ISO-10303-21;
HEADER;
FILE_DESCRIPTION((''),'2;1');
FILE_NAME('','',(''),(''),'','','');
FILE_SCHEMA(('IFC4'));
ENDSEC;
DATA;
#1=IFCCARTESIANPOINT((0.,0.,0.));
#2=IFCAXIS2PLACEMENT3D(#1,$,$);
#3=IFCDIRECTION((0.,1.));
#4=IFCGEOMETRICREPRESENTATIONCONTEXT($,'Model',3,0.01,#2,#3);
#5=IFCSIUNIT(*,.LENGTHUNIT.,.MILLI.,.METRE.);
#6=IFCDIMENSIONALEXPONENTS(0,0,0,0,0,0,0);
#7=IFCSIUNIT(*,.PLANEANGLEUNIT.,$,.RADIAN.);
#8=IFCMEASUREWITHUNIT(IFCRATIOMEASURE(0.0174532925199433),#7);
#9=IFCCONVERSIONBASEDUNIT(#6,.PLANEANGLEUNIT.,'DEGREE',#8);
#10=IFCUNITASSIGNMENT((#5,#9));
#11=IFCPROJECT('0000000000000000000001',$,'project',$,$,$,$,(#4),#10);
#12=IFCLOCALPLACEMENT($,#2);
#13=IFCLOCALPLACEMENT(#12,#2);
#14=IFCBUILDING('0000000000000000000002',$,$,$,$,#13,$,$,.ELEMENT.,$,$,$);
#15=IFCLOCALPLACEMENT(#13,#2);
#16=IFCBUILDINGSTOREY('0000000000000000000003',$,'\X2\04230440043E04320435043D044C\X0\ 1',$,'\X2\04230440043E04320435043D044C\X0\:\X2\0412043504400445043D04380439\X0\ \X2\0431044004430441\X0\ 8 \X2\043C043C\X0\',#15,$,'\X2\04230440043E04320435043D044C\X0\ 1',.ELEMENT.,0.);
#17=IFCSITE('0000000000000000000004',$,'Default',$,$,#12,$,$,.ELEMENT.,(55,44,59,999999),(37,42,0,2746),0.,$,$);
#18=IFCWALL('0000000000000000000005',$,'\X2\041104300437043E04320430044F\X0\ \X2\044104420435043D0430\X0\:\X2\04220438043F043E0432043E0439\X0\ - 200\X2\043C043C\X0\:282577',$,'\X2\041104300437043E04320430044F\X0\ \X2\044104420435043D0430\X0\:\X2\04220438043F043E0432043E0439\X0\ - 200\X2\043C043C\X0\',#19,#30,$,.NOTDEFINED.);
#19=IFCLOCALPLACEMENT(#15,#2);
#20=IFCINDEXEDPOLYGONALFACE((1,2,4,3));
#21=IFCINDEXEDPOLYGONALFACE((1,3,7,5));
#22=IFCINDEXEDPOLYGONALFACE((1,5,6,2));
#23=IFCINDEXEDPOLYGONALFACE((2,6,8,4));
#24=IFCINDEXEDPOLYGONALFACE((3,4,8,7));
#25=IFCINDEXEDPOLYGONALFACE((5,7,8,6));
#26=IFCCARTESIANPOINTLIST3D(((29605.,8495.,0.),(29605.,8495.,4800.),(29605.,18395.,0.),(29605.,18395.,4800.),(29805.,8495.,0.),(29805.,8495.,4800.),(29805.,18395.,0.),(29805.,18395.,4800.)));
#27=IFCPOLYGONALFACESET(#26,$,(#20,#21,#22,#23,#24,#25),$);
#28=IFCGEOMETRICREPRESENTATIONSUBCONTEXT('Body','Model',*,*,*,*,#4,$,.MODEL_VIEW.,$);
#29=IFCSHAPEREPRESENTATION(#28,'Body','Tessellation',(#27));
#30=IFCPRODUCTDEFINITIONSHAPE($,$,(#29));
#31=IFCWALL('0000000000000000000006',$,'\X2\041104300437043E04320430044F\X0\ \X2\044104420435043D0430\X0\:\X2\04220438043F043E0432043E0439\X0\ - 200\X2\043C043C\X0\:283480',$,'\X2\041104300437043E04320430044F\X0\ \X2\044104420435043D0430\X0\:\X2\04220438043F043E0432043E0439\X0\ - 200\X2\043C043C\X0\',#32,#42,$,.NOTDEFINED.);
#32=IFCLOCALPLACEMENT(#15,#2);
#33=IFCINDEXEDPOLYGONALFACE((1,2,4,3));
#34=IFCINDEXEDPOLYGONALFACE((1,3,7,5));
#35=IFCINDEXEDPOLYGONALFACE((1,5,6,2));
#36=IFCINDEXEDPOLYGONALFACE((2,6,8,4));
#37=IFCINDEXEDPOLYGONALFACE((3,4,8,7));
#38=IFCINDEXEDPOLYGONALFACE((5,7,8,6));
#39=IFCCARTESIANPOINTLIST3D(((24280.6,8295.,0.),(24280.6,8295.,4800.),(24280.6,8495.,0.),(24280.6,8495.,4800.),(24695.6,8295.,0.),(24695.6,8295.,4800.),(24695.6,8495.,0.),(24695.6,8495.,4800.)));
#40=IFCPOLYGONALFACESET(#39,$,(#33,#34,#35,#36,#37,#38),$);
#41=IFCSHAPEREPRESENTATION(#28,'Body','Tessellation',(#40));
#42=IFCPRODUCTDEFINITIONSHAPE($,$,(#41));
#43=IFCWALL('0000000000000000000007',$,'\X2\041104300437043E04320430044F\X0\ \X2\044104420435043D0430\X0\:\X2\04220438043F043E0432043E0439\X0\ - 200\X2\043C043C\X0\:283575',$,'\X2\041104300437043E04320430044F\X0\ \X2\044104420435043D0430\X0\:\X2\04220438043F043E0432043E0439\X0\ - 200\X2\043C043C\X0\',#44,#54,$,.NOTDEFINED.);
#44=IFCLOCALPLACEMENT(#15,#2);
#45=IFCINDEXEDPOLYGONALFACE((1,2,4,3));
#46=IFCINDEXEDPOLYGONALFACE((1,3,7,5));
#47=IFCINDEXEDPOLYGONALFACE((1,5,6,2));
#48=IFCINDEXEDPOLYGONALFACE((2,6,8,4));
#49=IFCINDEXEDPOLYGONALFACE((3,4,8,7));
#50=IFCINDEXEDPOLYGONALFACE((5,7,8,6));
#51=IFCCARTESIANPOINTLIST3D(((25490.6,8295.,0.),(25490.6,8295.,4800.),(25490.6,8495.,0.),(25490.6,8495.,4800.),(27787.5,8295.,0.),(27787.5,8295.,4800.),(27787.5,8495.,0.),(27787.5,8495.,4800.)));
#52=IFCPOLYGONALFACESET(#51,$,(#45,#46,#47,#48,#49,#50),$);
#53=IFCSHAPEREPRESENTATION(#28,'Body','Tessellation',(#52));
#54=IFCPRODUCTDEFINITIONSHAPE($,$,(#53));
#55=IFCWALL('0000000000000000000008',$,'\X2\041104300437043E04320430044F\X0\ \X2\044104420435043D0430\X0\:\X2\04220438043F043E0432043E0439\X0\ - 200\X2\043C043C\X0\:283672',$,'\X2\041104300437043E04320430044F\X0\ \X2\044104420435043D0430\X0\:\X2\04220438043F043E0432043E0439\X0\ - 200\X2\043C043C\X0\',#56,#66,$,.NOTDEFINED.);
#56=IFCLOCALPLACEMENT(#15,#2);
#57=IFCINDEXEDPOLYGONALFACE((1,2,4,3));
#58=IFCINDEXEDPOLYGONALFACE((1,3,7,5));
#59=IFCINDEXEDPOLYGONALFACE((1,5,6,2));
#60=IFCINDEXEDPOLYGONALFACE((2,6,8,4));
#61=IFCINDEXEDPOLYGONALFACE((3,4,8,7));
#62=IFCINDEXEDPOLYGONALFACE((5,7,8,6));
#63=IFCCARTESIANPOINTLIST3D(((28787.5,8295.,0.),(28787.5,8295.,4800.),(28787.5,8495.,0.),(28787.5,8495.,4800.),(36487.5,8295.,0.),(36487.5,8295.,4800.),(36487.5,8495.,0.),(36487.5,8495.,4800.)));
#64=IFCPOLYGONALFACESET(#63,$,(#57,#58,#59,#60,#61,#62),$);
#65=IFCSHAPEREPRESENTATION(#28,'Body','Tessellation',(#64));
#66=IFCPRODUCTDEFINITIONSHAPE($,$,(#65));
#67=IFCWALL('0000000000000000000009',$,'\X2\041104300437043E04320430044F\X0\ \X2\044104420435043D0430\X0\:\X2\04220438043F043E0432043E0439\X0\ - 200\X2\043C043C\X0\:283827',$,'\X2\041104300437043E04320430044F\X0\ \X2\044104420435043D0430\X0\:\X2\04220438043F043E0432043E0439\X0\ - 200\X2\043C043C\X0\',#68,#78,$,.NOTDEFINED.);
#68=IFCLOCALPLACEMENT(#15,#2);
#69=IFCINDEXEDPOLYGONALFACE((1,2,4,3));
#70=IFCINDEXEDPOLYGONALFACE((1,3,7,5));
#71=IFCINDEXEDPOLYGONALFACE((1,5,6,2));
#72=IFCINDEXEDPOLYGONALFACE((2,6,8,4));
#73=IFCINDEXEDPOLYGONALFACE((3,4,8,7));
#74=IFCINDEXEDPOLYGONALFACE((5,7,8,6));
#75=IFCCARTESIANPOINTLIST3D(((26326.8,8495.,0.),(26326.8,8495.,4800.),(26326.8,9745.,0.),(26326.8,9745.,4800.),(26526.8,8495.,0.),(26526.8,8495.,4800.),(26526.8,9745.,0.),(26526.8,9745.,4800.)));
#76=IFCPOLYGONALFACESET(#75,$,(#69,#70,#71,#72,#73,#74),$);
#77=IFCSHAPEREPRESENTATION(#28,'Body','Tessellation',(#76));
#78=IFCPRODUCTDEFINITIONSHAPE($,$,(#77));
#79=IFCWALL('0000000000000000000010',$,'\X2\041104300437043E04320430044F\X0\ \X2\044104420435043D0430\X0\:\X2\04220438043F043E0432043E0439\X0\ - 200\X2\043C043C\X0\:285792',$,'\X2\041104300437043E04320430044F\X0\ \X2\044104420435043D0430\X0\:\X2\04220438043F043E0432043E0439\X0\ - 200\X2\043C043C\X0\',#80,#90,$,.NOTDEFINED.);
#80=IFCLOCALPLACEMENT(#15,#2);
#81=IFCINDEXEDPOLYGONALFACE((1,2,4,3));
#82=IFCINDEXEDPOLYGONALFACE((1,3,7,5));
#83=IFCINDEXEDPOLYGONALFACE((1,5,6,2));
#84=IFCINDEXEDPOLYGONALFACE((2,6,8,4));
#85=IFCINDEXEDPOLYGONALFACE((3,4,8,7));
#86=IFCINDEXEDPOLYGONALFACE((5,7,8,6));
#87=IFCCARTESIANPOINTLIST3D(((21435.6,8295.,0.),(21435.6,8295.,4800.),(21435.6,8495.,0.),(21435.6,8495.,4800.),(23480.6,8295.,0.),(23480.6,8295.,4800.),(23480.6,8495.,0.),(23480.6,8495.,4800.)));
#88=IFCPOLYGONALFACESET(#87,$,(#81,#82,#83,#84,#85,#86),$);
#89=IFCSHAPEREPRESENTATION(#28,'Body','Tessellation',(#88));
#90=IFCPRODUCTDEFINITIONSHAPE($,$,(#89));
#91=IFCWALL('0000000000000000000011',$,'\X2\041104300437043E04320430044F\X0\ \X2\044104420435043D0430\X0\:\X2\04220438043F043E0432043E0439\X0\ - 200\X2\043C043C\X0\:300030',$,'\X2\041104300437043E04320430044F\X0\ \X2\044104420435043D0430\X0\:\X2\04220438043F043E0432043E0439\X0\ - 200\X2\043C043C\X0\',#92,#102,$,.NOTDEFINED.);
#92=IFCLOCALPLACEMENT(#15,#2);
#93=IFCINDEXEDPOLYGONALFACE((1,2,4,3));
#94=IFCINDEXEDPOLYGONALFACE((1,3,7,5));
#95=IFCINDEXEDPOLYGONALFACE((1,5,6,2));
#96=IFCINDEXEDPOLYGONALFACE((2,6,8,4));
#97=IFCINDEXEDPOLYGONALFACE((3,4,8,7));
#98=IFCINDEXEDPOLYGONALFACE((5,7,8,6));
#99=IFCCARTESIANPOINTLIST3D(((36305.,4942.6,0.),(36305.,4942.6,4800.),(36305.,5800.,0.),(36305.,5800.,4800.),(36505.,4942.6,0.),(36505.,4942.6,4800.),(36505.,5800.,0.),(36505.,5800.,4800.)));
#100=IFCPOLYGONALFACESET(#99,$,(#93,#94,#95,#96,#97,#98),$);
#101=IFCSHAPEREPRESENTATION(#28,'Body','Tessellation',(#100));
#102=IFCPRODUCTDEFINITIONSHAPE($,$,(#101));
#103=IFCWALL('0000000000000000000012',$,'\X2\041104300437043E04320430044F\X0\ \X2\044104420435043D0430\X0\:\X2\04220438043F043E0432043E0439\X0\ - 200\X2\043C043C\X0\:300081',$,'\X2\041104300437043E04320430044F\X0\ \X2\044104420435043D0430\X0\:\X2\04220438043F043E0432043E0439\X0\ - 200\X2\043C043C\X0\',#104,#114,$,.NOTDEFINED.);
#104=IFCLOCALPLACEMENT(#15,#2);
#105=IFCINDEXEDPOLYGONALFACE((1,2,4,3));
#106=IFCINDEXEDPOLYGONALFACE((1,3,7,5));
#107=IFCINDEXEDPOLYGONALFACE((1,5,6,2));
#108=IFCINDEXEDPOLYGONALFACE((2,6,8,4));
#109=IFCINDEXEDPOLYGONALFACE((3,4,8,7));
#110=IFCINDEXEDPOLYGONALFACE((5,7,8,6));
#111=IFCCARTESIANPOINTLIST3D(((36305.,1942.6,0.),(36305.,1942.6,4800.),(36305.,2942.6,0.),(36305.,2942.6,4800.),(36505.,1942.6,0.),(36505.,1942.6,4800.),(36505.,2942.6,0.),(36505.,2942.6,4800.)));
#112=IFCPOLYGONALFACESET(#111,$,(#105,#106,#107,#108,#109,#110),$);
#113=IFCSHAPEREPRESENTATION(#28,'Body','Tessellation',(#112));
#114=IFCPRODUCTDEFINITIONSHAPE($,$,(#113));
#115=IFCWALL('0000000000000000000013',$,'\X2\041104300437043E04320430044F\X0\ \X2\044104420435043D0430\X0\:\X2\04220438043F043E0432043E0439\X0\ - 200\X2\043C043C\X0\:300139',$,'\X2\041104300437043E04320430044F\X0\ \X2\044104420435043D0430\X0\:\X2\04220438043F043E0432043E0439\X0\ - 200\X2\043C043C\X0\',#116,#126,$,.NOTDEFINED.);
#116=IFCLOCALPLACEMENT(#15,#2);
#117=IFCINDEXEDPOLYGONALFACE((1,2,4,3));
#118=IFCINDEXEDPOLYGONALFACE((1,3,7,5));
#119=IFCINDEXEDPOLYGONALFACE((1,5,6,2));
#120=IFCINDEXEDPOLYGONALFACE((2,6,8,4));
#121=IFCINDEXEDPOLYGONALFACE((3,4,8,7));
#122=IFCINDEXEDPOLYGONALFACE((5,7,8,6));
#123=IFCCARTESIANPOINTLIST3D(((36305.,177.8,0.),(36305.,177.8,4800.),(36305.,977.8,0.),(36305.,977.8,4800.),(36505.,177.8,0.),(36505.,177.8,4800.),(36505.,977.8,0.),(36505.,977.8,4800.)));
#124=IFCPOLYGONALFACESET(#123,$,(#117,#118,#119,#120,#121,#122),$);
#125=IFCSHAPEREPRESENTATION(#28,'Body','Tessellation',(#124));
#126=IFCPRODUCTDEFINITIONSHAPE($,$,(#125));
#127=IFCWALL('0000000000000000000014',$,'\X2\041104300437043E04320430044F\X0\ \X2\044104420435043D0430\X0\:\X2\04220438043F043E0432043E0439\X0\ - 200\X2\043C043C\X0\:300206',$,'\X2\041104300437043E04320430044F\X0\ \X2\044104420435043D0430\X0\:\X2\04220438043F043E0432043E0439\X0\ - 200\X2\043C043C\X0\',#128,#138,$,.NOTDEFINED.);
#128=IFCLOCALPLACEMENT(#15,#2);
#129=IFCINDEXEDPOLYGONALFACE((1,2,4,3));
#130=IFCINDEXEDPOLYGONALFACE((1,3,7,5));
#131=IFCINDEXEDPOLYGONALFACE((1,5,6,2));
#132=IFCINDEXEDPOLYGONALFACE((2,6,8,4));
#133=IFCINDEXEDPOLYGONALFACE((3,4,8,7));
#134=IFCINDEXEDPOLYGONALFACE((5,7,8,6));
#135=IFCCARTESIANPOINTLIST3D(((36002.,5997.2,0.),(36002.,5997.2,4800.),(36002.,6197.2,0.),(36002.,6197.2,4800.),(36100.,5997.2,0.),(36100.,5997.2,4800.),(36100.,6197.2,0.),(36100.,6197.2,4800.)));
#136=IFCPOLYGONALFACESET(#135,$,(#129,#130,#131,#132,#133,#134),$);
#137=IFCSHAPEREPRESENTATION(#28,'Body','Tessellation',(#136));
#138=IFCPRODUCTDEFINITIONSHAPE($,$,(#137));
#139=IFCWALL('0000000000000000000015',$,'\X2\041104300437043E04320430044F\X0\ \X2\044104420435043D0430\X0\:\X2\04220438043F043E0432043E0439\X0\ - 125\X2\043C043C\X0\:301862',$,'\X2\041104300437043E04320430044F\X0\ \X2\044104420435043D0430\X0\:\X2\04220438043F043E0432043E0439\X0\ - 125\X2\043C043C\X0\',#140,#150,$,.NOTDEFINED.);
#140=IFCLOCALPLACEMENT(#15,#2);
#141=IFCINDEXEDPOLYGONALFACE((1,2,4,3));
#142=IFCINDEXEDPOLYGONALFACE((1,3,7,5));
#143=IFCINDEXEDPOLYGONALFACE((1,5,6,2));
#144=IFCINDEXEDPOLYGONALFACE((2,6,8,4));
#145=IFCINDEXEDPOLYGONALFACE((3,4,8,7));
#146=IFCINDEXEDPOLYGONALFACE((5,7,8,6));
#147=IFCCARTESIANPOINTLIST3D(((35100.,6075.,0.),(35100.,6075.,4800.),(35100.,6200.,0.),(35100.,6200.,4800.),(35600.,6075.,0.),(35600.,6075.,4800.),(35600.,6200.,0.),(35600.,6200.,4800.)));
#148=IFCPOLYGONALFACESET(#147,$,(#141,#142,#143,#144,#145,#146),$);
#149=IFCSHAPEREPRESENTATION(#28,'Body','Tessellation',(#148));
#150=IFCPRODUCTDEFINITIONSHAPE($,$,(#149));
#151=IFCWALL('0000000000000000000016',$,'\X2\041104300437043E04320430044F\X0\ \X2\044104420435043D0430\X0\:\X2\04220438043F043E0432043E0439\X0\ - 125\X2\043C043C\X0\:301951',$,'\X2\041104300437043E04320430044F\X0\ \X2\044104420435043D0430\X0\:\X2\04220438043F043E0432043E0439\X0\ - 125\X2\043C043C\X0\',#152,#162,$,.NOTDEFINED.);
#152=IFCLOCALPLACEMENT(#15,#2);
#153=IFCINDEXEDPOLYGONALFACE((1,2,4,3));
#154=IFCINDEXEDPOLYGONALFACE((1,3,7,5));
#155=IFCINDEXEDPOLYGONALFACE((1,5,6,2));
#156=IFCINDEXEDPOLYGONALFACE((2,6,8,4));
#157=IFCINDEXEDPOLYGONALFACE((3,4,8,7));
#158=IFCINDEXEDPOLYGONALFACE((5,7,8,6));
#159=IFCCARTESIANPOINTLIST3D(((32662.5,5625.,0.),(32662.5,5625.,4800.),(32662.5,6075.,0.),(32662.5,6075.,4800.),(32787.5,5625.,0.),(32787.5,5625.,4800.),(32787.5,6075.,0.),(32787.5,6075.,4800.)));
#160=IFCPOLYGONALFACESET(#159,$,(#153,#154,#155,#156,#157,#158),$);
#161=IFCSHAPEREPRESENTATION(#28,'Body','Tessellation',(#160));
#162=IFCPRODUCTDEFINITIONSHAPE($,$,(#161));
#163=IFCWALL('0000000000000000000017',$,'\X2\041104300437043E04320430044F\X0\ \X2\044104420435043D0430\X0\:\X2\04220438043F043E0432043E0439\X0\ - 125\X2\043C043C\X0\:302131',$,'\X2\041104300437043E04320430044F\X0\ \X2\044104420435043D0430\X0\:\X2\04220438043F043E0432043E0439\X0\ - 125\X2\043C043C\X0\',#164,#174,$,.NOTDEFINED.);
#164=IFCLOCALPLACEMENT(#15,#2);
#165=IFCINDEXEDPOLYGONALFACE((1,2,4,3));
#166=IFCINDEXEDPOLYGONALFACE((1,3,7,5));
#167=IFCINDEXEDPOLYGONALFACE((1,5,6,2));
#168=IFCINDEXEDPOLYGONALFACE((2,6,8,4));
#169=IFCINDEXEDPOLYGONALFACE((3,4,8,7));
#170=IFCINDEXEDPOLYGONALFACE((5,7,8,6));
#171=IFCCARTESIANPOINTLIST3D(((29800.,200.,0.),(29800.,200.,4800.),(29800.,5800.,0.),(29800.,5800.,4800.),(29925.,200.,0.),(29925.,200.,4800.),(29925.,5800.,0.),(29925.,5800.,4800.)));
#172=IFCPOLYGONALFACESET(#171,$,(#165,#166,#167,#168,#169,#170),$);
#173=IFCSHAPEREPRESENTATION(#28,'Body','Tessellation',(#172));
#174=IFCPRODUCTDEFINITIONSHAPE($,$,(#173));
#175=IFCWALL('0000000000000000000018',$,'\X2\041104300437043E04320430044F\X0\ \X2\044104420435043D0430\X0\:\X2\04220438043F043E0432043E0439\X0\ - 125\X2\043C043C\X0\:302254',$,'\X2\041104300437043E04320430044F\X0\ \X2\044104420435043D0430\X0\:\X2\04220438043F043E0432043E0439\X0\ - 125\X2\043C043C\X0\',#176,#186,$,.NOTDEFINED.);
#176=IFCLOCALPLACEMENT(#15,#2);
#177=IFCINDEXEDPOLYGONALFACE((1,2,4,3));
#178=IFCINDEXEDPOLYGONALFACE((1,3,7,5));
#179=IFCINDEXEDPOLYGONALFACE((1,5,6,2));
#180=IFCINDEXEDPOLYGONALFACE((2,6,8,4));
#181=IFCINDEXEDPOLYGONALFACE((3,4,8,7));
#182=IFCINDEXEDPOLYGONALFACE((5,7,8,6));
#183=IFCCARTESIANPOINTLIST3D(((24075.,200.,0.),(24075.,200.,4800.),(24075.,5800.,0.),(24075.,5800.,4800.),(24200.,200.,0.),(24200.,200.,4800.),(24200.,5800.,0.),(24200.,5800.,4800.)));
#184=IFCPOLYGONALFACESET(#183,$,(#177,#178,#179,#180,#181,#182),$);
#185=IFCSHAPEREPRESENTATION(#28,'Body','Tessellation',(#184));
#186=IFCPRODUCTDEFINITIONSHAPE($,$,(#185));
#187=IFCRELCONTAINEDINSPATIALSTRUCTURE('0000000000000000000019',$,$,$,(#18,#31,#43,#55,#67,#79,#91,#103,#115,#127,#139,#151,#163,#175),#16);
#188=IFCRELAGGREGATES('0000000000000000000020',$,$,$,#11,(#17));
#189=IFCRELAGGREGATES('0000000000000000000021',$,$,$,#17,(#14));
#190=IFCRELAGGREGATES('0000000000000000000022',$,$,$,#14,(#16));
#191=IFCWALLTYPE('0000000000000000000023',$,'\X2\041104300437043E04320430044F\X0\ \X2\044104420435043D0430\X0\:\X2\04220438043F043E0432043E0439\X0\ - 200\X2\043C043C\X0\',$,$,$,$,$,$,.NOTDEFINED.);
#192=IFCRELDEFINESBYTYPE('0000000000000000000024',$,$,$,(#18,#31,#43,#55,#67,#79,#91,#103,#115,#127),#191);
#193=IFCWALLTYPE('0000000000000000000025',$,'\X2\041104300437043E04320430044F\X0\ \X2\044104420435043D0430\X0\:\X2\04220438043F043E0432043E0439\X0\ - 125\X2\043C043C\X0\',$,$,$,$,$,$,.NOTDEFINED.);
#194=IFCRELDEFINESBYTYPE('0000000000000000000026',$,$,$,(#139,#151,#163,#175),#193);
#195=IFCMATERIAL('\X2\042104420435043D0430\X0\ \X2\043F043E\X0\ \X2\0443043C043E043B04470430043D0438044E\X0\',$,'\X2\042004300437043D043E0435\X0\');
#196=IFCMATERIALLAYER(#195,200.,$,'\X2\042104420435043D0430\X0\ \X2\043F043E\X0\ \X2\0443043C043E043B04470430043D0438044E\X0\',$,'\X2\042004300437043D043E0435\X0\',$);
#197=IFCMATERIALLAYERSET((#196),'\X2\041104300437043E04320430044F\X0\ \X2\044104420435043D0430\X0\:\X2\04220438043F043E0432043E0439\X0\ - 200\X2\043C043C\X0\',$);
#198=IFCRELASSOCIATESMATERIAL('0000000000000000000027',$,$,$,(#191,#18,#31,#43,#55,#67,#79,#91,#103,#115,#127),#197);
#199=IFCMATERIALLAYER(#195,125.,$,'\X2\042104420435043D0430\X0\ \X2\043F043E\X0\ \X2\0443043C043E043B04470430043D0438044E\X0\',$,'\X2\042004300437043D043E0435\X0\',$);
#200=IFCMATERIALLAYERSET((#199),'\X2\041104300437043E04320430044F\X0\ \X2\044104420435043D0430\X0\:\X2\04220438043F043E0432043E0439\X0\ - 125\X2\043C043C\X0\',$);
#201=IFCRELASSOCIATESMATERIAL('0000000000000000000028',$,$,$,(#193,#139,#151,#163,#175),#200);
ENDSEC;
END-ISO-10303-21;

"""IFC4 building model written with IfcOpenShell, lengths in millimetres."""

from ifc_helpers import new_model, entity, si_unit, converted_unit, direction, frame, frame_2d, origin, place, context, subcontext, project, spatial, rectangle, extrude, material, layer, layer_set, layer_usage, type_object, element, save


model = new_model("IFC4")

# Units and contexts
model_context = context("Model", 3, precision=0.01, world=origin(), true_north=direction((0.0, 1.0)))
body_context = subcontext(model_context, "Body", "Model", "MODEL_VIEW")
ifc_project = project(units=[si_unit("LENGTHUNIT", "METRE", prefix="MILLI"), converted_unit("PLANEANGLEUNIT", "DEGREE", entity("IfcRatioMeasure", 0.0174532925199433), si_unit("PLANEANGLEUNIT", "RADIAN"), dimensions=[0, 0, 0, 0, 0, 0, 0])], contexts=[model_context])

# Site, building, storey
site_placement = place(None, origin())
site = spatial("IfcSite", under=ifc_project, at=site_placement, Name="Default", CompositionType="ELEMENT", RefLatitude=(55, 44, 59, 999999), RefLongitude=(37, 42, 0, 2746), RefElevation=0.0)
building_placement = place(site_placement, origin())
building = spatial("IfcBuilding", under=site, at=building_placement, CompositionType="ELEMENT")
storey_placement = place(building_placement, origin())
storey = spatial("IfcBuildingStorey", under=building, at=storey_placement, Name="Уровень 1", ObjectType="Уровень:Верхний брус 8 мм", LongName="Уровень 1", CompositionType="ELEMENT", Elevation=0.0)

# Walls
ifc_material_1 = material(Name="Стена по умолчанию", Category="Разное")
ifc_layer_1 = layer(ifc_material_1, 200.0, Name="Стена по умолчанию", Category="Разное")
ifc_layer_set_1 = layer_set([ifc_layer_1], Name="Базовая стена:Типовой - 200мм")
ifc_layer_usage_1 = layer_usage(ifc_layer_set_1, "AXIS2", "NEGATIVE", 100.0)
wall_type_1 = type_object("IfcWallType", Name="Базовая стена:Типовой - 200мм", PredefinedType="NOTDEFINED", material=ifc_layer_set_1)
wall_1_placement = place(storey_placement, frame((29705.0, 8495.0, 0.0), z_axis=(0.0, 0.0, 1.0), x_axis=(0.0, 1.0, 0.0)))
element("IfcWall", 1, at=wall_1_placement, inside=storey, type_object=wall_type_1, material=ifc_layer_usage_1, Name="Базовая стена:Типовой - 200мм:282577", ObjectType="Базовая стена:Типовой - 200мм", PredefinedType="NOTDEFINED", context=body_context, shape_type="SweptSolid", body=[
    extrude(rectangle(XDim=9900.0, YDim=200.0, at=frame_2d((4950.0, 0.0), x_axis=(-1.0, 0.0))), origin(), (0.0, 0.0, 1.0), 4800.0),
])
ifc_layer_usage_2 = layer_usage(ifc_layer_set_1, "AXIS2", "NEGATIVE", 100.0)
wall_2_placement = place(storey_placement, frame((24280.6, 8395.0, 0.0)))
element("IfcWall", 2, at=wall_2_placement, inside=storey, type_object=wall_type_1, material=ifc_layer_usage_2, Name="Базовая стена:Типовой - 200мм:283480", ObjectType="Базовая стена:Типовой - 200мм", PredefinedType="NOTDEFINED", context=body_context, shape_type="SweptSolid", body=[
    extrude(rectangle(XDim=415.0, YDim=200.0, at=frame_2d((207.5, 0.0), x_axis=(-1.0, 0.0))), origin(), (0.0, 0.0, 1.0), 4800.0),
])
ifc_layer_usage_3 = layer_usage(ifc_layer_set_1, "AXIS2", "NEGATIVE", 100.0)
wall_3_placement = place(storey_placement, frame((25490.6, 8395.0, 0.0)))
element("IfcWall", 3, at=wall_3_placement, inside=storey, type_object=wall_type_1, material=ifc_layer_usage_3, Name="Базовая стена:Типовой - 200мм:283575", ObjectType="Базовая стена:Типовой - 200мм", PredefinedType="NOTDEFINED", context=body_context, shape_type="SweptSolid", body=[
    extrude(rectangle(XDim=2296.9, YDim=200.0, at=frame_2d((1148.5, 0.0), x_axis=(-1.0, 0.0))), origin(), (0.0, 0.0, 1.0), 4800.0),
])
ifc_layer_usage_4 = layer_usage(ifc_layer_set_1, "AXIS2", "NEGATIVE", 100.0)
wall_4_placement = place(storey_placement, frame((28787.5, 8395.0, 0.0)))
element("IfcWall", 4, at=wall_4_placement, inside=storey, type_object=wall_type_1, material=ifc_layer_usage_4, Name="Базовая стена:Типовой - 200мм:283672", ObjectType="Базовая стена:Типовой - 200мм", PredefinedType="NOTDEFINED", context=body_context, shape_type="SweptSolid", body=[
    extrude(rectangle(XDim=7700.0, YDim=200.0, at=frame_2d((3850.0, 0.0), x_axis=(-1.0, 0.0))), origin(), (0.0, 0.0, 1.0), 4800.0),
])
ifc_layer_usage_5 = layer_usage(ifc_layer_set_1, "AXIS2", "NEGATIVE", 100.0)
wall_5_placement = place(storey_placement, frame((26426.8, 9745.0, 0.0), z_axis=(0.0, 0.0, 1.0), x_axis=(0.0, -1.0, 0.0)))
element("IfcWall", 5, at=wall_5_placement, inside=storey, type_object=wall_type_1, material=ifc_layer_usage_5, Name="Базовая стена:Типовой - 200мм:283827", ObjectType="Базовая стена:Типовой - 200мм", PredefinedType="NOTDEFINED", context=body_context, shape_type="SweptSolid", body=[
    extrude(rectangle(XDim=1250.0, YDim=200.0, at=frame_2d((625.0, 0.0), x_axis=(-1.0, 0.0))), origin(), (0.0, 0.0, 1.0), 4800.0),
])
ifc_layer_usage_6 = layer_usage(ifc_layer_set_1, "AXIS2", "NEGATIVE", 100.0)
wall_6_placement = place(storey_placement, frame((23480.6, 8395.0, 0.0), z_axis=(0.0, 0.0, 1.0), x_axis=(-1.0, 0.0, 0.0)))
element("IfcWall", 6, at=wall_6_placement, inside=storey, type_object=wall_type_1, material=ifc_layer_usage_6, Name="Базовая стена:Типовой - 200мм:285792", ObjectType="Базовая стена:Типовой - 200мм", PredefinedType="NOTDEFINED", context=body_context, shape_type="SweptSolid", body=[
    extrude(rectangle(XDim=2045.0, YDim=200.0, at=frame_2d((1022.5, 0.0), x_axis=(-1.0, 0.0))), origin(), (0.0, 0.0, 1.0), 4800.0),
])
ifc_layer_usage_7 = layer_usage(ifc_layer_set_1, "AXIS2", "NEGATIVE", 100.0)
wall_7_placement = place(storey_placement, frame((36405.0, 5800.0, 0.0), z_axis=(0.0, 0.0, 1.0), x_axis=(0.0, -1.0, 0.0)))
element("IfcWall", 7, at=wall_7_placement, inside=storey, type_object=wall_type_1, material=ifc_layer_usage_7, Name="Базовая стена:Типовой - 200мм:300030", ObjectType="Базовая стена:Типовой - 200мм", PredefinedType="NOTDEFINED", context=body_context, shape_type="SweptSolid", body=[
    extrude(rectangle(XDim=857.4, YDim=200.0, at=frame_2d((428.7, 0.0), x_axis=(-1.0, 0.0))), origin(), (0.0, 0.0, 1.0), 4800.0),
])
ifc_layer_usage_8 = layer_usage(ifc_layer_set_1, "AXIS2", "NEGATIVE", 100.0)
wall_8_placement = place(storey_placement, frame((36405.0, 2942.6, 0.0), z_axis=(0.0, 0.0, 1.0), x_axis=(0.0, -1.0, 0.0)))
element("IfcWall", 8, at=wall_8_placement, inside=storey, type_object=wall_type_1, material=ifc_layer_usage_8, Name="Базовая стена:Типовой - 200мм:300081", ObjectType="Базовая стена:Типовой - 200мм", PredefinedType="NOTDEFINED", context=body_context, shape_type="SweptSolid", body=[
    extrude(rectangle(XDim=1000.0, YDim=200.0, at=frame_2d((500.0, 0.0), x_axis=(-1.0, 0.0))), origin(), (0.0, 0.0, 1.0), 4800.0),
])
ifc_layer_usage_9 = layer_usage(ifc_layer_set_1, "AXIS2", "NEGATIVE", 100.0)
wall_9_placement = place(storey_placement, frame((36405.0, 977.8, 0.0), z_axis=(0.0, 0.0, 1.0), x_axis=(0.0, -1.0, 0.0)))
element("IfcWall", 9, at=wall_9_placement, inside=storey, type_object=wall_type_1, material=ifc_layer_usage_9, Name="Базовая стена:Типовой - 200мм:300139", ObjectType="Базовая стена:Типовой - 200мм", PredefinedType="NOTDEFINED", context=body_context, shape_type="SweptSolid", body=[
    extrude(rectangle(XDim=800.0, YDim=200.0, at=frame_2d((400.0, 0.0), x_axis=(-1.0, 0.0))), origin(), (0.0, 0.0, 1.0), 4800.0),
])
ifc_layer_usage_10 = layer_usage(ifc_layer_set_1, "AXIS2", "NEGATIVE", 100.0)
wall_10_placement = place(storey_placement, frame((36100.0, 6097.2, 0.0), z_axis=(0.0, 0.0, 1.0), x_axis=(-1.0, 0.0, 0.0)))
element("IfcWall", 10, at=wall_10_placement, inside=storey, type_object=wall_type_1, material=ifc_layer_usage_10, Name="Базовая стена:Типовой - 200мм:300206", ObjectType="Базовая стена:Типовой - 200мм", PredefinedType="NOTDEFINED", context=body_context, shape_type="SweptSolid", body=[
    extrude(rectangle(XDim=98.0, YDim=200.0, at=frame_2d((49.0, 0.0), x_axis=(-1.0, 0.0))), origin(), (0.0, 0.0, 1.0), 4800.0),
])

# Shared definitions
ifc_layer_2 = layer(ifc_material_1, 125.0, Name="Стена по умолчанию", Category="Разное")
ifc_layer_set_2 = layer_set([ifc_layer_2], Name="Базовая стена:Типовой - 125мм")
wall_type_2 = type_object("IfcWallType", Name="Базовая стена:Типовой - 125мм", PredefinedType="NOTDEFINED", material=ifc_layer_set_2)

# Walls
ifc_layer_usage_11 = layer_usage(ifc_layer_set_2, "AXIS2", "NEGATIVE", 62.5)
wall_11_placement = place(storey_placement, frame((35100.0, 6137.5, 0.0)))
element("IfcWall", 11, at=wall_11_placement, inside=storey, type_object=wall_type_2, material=ifc_layer_usage_11, Name="Базовая стена:Типовой - 125мм:301862", ObjectType="Базовая стена:Типовой - 125мм", PredefinedType="NOTDEFINED", context=body_context, shape_type="SweptSolid", body=[
    extrude(rectangle(XDim=500.0, YDim=125.0, at=frame_2d((250.0, 0.0), x_axis=(-1.0, 0.0))), origin(), (0.0, 0.0, 1.0), 4800.0),
])
ifc_layer_usage_12 = layer_usage(ifc_layer_set_2, "AXIS2", "NEGATIVE", 62.5)
wall_12_placement = place(storey_placement, frame((32725.0, 6075.0, 0.0), z_axis=(0.0, 0.0, 1.0), x_axis=(0.0, -1.0, 0.0)))
element("IfcWall", 12, at=wall_12_placement, inside=storey, type_object=wall_type_2, material=ifc_layer_usage_12, Name="Базовая стена:Типовой - 125мм:301951", ObjectType="Базовая стена:Типовой - 125мм", PredefinedType="NOTDEFINED", context=body_context, shape_type="SweptSolid", body=[
    extrude(rectangle(XDim=450.0, YDim=125.0, at=frame_2d((225.0, 0.0), x_axis=(-1.0, 0.0))), origin(), (0.0, 0.0, 1.0), 4800.0),
])

# Walls
ifc_layer_usage_13 = layer_usage(ifc_layer_set_2, "AXIS2", "NEGATIVE", 62.5)
wall_13_placement = place(storey_placement, frame((29862.5, 5800.0, 0.0), z_axis=(0.0, 0.0, 1.0), x_axis=(0.0, -1.0, 0.0)))
element("IfcWall", 13, at=wall_13_placement, inside=storey, type_object=wall_type_2, material=ifc_layer_usage_13, Name="Базовая стена:Типовой - 125мм:302131", ObjectType="Базовая стена:Типовой - 125мм", PredefinedType="NOTDEFINED", context=body_context, shape_type="SweptSolid", body=[
    extrude(rectangle(XDim=5600.0, YDim=125.0, at=frame_2d((2800.0, 0.0), x_axis=(-1.0, 0.0))), origin(), (0.0, 0.0, 1.0), 4800.0),
])
ifc_layer_usage_14 = layer_usage(ifc_layer_set_2, "AXIS2", "NEGATIVE", 62.5)
wall_14_placement = place(storey_placement, frame((24137.5, 5800.0, 0.0), z_axis=(0.0, 0.0, 1.0), x_axis=(0.0, -1.0, 0.0)))
element("IfcWall", 14, at=wall_14_placement, inside=storey, type_object=wall_type_2, material=ifc_layer_usage_14, Name="Базовая стена:Типовой - 125мм:302254", ObjectType="Базовая стена:Типовой - 125мм", PredefinedType="NOTDEFINED", context=body_context, shape_type="SweptSolid", body=[
    extrude(rectangle(XDim=5600.0, YDim=125.0, at=frame_2d((2800.0, 0.0), x_axis=(-1.0, 0.0))), origin(), (0.0, 0.0, 1.0), 4800.0),
])

save(model, "model.ifc")
